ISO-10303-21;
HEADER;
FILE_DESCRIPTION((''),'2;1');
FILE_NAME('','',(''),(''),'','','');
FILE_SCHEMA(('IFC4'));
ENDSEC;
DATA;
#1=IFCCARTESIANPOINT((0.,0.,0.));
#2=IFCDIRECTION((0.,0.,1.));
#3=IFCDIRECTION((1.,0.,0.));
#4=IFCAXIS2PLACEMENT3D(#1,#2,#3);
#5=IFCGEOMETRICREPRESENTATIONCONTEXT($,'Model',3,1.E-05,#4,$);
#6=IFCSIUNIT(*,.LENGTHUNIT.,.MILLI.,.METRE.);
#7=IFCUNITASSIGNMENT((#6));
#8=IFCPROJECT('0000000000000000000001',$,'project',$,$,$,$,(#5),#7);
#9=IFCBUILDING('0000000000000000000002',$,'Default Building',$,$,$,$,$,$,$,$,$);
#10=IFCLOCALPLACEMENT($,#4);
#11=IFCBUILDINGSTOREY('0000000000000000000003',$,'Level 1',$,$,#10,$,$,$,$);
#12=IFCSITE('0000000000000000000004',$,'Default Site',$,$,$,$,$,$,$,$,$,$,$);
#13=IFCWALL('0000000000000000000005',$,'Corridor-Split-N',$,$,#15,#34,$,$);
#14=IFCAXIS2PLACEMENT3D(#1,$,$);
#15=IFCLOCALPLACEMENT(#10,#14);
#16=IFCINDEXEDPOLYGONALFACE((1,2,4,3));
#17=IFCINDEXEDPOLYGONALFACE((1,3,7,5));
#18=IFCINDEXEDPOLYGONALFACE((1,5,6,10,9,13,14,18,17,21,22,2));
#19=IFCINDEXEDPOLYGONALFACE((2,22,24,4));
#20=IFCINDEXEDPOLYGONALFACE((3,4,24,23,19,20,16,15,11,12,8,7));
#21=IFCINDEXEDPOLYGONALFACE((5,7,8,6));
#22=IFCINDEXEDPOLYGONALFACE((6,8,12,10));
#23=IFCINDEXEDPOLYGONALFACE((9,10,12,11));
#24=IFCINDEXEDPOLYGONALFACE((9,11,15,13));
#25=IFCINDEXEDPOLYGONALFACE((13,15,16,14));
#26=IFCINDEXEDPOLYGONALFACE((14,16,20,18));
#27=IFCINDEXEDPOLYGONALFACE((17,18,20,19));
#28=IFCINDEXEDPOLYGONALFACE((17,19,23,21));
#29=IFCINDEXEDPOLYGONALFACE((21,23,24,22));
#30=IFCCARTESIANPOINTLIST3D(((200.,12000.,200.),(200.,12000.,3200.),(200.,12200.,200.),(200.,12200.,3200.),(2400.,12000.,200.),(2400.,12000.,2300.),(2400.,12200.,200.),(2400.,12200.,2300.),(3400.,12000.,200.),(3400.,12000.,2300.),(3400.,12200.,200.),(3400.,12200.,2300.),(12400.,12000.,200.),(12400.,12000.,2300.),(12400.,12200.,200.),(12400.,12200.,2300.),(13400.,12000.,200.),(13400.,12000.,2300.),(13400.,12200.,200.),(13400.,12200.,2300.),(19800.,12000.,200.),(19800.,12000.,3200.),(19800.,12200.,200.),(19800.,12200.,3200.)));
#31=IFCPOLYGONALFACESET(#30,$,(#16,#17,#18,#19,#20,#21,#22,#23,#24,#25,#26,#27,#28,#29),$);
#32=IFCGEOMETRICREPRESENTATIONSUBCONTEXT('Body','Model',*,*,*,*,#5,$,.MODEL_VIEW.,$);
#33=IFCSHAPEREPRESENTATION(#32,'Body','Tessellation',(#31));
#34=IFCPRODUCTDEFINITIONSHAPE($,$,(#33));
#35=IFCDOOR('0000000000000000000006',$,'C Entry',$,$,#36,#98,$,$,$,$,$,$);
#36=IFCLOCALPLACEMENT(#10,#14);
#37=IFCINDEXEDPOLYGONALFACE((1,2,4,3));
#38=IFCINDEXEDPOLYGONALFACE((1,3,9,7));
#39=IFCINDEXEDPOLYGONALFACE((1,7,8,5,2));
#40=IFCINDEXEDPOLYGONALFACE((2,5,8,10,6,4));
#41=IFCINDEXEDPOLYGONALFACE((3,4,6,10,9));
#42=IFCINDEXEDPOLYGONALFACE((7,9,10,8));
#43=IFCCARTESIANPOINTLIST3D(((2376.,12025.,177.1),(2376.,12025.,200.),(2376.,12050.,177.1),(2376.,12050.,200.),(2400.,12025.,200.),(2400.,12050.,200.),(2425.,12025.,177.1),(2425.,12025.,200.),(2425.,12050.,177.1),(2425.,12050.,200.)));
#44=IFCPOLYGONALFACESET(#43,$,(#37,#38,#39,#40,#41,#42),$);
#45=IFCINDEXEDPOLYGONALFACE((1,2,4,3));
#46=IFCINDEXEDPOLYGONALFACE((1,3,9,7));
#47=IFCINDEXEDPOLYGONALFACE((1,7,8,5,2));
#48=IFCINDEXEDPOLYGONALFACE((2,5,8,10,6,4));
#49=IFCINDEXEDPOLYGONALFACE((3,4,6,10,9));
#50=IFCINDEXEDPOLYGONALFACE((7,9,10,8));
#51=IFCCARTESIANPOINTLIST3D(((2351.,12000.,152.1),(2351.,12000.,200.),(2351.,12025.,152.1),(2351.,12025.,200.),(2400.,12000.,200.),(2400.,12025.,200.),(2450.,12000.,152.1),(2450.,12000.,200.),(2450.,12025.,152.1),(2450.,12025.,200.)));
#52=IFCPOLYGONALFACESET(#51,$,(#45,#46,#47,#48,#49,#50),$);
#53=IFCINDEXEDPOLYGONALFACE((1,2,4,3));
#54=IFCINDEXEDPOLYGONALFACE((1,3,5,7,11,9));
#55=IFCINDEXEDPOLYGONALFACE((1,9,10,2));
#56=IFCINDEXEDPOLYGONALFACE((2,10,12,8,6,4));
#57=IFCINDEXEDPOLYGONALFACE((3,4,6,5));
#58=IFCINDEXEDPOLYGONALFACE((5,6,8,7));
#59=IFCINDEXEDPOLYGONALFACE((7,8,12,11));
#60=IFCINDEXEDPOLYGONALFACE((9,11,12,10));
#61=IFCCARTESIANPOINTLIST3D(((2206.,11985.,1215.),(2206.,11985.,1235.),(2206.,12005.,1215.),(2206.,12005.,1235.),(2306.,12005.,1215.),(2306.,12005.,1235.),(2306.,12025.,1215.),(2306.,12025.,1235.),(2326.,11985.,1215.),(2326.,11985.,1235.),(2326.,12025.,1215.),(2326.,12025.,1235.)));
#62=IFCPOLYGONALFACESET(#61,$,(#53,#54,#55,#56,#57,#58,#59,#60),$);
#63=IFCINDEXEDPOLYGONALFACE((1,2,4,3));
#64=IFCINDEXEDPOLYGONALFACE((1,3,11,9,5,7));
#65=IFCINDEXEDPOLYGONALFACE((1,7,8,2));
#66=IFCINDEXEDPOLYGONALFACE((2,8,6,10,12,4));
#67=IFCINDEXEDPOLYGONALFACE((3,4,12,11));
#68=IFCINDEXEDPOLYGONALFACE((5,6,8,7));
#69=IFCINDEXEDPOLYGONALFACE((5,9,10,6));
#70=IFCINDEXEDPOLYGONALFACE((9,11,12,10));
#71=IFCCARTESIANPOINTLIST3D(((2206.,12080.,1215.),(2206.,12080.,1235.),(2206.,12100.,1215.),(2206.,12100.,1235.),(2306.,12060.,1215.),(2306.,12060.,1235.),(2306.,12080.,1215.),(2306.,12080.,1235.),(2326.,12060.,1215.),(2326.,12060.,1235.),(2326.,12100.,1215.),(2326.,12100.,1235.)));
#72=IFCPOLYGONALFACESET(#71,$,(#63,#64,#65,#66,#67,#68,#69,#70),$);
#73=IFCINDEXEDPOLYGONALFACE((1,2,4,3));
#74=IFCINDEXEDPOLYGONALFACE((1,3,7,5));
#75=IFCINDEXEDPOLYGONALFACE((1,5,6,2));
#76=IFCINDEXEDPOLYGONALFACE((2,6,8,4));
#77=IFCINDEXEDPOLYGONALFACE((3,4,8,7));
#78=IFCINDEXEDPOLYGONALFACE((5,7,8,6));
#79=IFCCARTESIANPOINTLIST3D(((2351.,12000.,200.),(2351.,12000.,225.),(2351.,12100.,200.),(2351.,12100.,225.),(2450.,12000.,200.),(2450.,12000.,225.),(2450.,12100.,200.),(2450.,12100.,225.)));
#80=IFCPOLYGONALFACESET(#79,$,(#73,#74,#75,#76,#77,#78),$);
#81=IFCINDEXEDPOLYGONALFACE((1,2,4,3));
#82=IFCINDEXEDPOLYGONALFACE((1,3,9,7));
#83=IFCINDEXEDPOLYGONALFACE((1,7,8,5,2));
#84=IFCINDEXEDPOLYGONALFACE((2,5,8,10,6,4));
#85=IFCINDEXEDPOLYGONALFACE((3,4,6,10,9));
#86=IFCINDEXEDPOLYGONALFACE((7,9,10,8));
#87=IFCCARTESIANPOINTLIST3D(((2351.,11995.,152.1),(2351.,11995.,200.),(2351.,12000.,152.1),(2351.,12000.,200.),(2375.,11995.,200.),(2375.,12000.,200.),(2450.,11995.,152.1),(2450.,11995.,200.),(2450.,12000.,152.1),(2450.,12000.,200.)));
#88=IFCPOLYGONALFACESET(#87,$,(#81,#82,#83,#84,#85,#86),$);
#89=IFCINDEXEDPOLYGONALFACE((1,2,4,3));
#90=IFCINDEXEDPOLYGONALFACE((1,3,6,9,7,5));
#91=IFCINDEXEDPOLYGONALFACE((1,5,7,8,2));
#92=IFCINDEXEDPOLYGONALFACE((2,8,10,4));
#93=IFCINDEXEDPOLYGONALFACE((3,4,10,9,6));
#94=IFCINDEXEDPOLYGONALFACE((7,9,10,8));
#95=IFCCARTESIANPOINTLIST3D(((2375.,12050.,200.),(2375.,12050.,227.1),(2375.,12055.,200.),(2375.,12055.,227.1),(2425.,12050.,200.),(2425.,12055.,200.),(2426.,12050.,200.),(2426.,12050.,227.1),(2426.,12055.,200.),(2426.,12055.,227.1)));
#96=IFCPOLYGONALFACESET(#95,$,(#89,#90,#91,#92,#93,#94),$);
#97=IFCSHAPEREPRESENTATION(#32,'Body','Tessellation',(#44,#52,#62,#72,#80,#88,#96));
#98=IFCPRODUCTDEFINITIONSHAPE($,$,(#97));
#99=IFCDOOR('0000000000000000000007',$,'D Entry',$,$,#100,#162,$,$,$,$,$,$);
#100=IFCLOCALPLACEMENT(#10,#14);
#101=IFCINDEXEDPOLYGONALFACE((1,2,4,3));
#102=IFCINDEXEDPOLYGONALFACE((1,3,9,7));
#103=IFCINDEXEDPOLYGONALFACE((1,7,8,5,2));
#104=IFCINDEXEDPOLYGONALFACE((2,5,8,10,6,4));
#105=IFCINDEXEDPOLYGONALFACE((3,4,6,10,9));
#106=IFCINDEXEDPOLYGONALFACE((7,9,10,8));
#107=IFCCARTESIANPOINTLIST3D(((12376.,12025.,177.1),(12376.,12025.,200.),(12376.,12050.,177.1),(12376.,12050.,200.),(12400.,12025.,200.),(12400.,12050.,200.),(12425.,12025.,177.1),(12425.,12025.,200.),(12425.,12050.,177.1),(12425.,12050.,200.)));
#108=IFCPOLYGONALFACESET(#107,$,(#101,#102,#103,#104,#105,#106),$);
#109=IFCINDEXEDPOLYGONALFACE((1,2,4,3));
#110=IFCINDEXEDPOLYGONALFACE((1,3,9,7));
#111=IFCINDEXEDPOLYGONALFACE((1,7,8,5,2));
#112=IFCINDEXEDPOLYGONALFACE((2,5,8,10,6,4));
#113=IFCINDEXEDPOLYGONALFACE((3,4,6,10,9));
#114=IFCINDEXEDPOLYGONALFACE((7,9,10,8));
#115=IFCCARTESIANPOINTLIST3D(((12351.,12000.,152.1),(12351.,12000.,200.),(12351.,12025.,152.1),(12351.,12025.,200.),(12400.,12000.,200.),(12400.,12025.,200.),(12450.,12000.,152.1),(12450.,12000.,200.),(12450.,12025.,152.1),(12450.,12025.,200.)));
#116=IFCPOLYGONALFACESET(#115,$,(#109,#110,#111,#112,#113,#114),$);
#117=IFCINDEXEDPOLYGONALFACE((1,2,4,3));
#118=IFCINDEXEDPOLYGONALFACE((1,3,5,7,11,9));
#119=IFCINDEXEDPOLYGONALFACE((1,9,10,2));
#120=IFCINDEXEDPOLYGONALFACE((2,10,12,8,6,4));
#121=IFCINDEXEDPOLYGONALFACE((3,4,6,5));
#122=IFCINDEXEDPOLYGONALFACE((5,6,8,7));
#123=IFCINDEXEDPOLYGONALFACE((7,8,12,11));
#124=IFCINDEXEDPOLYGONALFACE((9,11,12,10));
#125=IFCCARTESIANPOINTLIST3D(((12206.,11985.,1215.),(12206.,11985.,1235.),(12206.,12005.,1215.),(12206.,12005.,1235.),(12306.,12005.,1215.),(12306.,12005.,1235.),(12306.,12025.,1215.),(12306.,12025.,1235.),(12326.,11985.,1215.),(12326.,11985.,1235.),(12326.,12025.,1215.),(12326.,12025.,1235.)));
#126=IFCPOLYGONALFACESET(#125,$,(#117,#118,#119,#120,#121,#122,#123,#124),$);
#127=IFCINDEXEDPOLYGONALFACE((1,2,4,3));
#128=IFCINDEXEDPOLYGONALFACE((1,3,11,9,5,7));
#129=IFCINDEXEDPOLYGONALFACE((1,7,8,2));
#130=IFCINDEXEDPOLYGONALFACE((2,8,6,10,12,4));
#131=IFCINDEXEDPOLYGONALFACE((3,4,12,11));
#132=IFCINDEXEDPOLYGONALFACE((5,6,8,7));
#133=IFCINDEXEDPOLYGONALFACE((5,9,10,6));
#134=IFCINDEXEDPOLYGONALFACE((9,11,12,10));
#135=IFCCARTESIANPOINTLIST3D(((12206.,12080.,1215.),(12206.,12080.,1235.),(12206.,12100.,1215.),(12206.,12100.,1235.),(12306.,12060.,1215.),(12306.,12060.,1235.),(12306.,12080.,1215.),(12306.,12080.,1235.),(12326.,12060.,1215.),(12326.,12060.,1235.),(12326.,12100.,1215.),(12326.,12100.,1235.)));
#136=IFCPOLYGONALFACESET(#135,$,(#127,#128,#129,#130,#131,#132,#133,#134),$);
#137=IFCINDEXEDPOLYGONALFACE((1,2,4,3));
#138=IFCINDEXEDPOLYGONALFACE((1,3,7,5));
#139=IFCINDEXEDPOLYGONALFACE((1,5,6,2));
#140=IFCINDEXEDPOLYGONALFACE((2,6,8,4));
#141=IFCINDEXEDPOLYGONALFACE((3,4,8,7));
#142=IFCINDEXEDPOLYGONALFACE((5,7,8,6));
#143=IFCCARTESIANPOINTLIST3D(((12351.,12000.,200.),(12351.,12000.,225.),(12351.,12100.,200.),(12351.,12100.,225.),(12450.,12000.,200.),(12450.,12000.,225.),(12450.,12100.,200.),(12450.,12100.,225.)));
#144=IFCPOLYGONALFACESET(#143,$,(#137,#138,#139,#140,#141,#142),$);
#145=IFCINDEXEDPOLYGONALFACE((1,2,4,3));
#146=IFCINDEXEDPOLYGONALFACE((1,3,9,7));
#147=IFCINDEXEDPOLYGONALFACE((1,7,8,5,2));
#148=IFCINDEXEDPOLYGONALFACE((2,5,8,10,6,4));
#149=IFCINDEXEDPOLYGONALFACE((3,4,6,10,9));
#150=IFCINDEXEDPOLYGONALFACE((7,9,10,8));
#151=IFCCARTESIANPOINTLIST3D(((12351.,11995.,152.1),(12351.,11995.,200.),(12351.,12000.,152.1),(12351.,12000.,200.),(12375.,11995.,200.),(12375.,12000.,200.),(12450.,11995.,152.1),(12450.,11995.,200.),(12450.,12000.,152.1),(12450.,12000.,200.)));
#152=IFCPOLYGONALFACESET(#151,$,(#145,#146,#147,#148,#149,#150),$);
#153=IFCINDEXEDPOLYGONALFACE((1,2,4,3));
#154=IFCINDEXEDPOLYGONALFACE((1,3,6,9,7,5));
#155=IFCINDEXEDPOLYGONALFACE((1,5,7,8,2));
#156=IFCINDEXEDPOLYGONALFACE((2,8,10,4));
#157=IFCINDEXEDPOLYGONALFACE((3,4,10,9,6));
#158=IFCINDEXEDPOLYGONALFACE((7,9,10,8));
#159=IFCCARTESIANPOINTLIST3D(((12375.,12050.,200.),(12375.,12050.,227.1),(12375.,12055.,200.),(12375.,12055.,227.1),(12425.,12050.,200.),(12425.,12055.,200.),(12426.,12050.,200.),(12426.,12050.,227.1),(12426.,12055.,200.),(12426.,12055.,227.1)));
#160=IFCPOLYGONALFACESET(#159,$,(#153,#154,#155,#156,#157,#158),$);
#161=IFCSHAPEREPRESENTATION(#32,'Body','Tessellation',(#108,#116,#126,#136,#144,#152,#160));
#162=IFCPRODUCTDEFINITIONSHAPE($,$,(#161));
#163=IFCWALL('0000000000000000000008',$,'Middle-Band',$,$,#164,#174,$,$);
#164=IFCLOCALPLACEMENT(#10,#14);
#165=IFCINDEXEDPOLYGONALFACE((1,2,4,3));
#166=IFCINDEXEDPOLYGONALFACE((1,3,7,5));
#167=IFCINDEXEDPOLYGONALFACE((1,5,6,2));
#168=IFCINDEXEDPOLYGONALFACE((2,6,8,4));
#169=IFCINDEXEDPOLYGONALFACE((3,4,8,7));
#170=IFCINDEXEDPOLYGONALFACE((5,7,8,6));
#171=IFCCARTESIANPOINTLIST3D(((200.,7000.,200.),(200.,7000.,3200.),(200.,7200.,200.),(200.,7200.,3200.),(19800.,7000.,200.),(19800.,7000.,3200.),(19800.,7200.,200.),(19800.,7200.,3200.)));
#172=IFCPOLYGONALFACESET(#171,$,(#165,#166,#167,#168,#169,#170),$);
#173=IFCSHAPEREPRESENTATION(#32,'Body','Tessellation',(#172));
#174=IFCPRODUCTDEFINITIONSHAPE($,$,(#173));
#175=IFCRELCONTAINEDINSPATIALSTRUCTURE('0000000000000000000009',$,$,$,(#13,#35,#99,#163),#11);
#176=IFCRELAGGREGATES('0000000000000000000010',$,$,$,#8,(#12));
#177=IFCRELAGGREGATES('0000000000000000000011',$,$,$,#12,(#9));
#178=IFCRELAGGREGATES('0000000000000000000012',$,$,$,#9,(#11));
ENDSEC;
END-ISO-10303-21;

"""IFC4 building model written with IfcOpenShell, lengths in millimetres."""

from ifc_helpers import new_model, si_unit, frame, origin_with_axes, place, context, subcontext, project, spatial, line, indexed_curve, outline, extrude, element, fill, save


model = new_model("IFC4")

# Units and contexts
model_context = context("Model", 3, precision=1e-05, world=origin_with_axes())
body_context = subcontext(model_context, "Body", "Model", "MODEL_VIEW")
ifc_project = project(units=[si_unit("LENGTHUNIT", "METRE", prefix="MILLI")], contexts=[model_context])

# Site, building, storey
site = spatial("IfcSite", under=ifc_project, Name="Default Site")
building = spatial("IfcBuilding", under=site, Name="Default Building")
storey_placement = place(None, origin_with_axes())
storey = spatial("IfcBuildingStorey", under=building, at=storey_placement, Name="Level 1")

# Wall, openings, doors
wall_1_placement = place(storey_placement, frame((0.0, 0.0, 200.0), z_axis=(0.0, 0.0, 1.0), x_axis=(1.0, 0.0, 0.0)))
wall_1 = element("IfcWall", 1, at=wall_1_placement, inside=storey, Name="Corridor-Split-N", context=body_context, shape_type="SweptSolid", body=[
    extrude(outline(indexed_curve([(200.0, 12000.0), (19800.0, 12000.0), (19800.0, 12200.0), (200.0, 12200.0), (200.0, 12000.0)])), None, (0.0, 0.0, 1.0), 3000.0),
])
opening_1_placement = place(wall_1_placement, origin_with_axes())
opening_1 = element("IfcOpeningElement", 2, at=opening_1_placement, cuts=wall_1, context=body_context, shape_type="SweptSolid", body=[
    extrude(outline(indexed_curve([(2400.0, 12000.0), (3400.0, 12000.0), (3400.0, 12200.0), (2400.0, 12200.0), (2400.0, 12000.0)])), None, (0.0, 0.0, 1.0), 2100.0),
])
opening_2_placement = place(wall_1_placement, origin_with_axes())
opening_2 = element("IfcOpeningElement", 3, at=opening_2_placement, cuts=wall_1, context=body_context, shape_type="SweptSolid", body=[
    extrude(outline(indexed_curve([(12400.0, 12000.0), (13400.0, 12000.0), (13400.0, 12200.0), (12400.0, 12200.0), (12400.0, 12000.0)])), None, (0.0, 0.0, 1.0), 2100.0),
])
door_1_placement = place(storey_placement, frame((2400.0, 12000.0, 200.0), z_axis=(0.0, 0.0, 1.0), x_axis=(1.0, 0.0, 0.0)))
door_1 = element("IfcDoor", 4, at=door_1_placement, inside=storey, Name="C Entry", context=body_context, shape_type="SweptSolid", body=[
    extrude(outline(indexed_curve([(0.0, 0.0), (0.0, 2.1), (1.0, 2.1), (1.0, 0.0), (-24.0, 0.0), (-24.0, -22.9), (25.0, -22.9), (25.0, 0.0)], segments=[line(1, 2, 3, 4, 5, 6, 7, 8, 1)])), frame((0.0, 25.0, 0.0), z_axis=(0.0, -1.0, 0.0), x_axis=(1.0, 0.0, 0.0)), (0.0, 0.0, -1.0), 25.0),
    extrude(outline(indexed_curve([(0.0, 0.0), (0.0, 2.1), (1.0, 2.1), (1.0, 0.0), (-49.0, 0.0), (-49.0, -47.9), (50.0, -47.9), (50.0, 0.0)], segments=[line(1, 2, 3, 4, 5, 6, 7, 8, 1)])), frame((0.0, 0.0, 0.0), z_axis=(0.0, -1.0, 0.0), x_axis=(1.0, 0.0, 0.0)), (0.0, 0.0, -1.0), 25.0),
    extrude(outline(indexed_curve([(0.0, 0.0), (-49.0, 0.0), (-49.0, 35.0), (0.0, 35.0)], segments=[line(1, 2, 3, 4, 1)])), frame((25.0, 25.0, 25.0), z_axis=(0.0, 0.0, 1.0), x_axis=(1.0, 0.0, 0.0)), (0.0, 0.0, 1.0), -47.9),
    extrude(outline(indexed_curve([(0.0, 0.0), (0.0, -40.0), (-120.0, -40.0), (-120.0, -20.0), (-20.0, -20.0), (-20.0, 0.0)], segments=[line(1, 2, 3, 4, 5, 6, 1)])), frame((-74.0, 25.0, 1015.0), z_axis=(0.0, 0.0, 1.0), x_axis=(1.0, 0.0, 0.0)), (0.0, 0.0, 1.0), 20.0),
    extrude(outline(indexed_curve([(0.0, 0.0), (0.0, 40.0), (-120.0, 40.0), (-120.0, 20.0), (-20.0, 20.0), (-20.0, 0.0)], segments=[line(1, 2, 3, 4, 5, 6, 1)])), frame((-74.0, 60.0, 1015.0), z_axis=(0.0, 0.0, 1.0), x_axis=(1.0, 0.0, 0.0)), (0.0, 0.0, 1.0), 20.0),
    extrude(outline(indexed_curve([(0.0, 0.0), (-99.0, 0.0), (-99.0, 100.0), (0.0, 100.0)], segments=[line(1, 2, 3, 4, 1)])), frame((50.0, 0.0, 0.0), z_axis=(0.0, 0.0, 1.0), x_axis=(1.0, 0.0, 0.0)), (0.0, 0.0, 1.0), 25.0),
    extrude(outline(indexed_curve([(0.0, 0.0), (0.0, 27.1), (51.0, 27.1), (51.0, 0.0), (-24.0, 0.0), (-24.0, -47.9), (75.0, -47.9), (75.0, 0.0)], segments=[line(1, 2, 3, 4, 5, 6, 7, 8, 1)])), frame((-25.0, -5.0, 0.0), z_axis=(0.0, -1.0, 0.0), x_axis=(1.0, 0.0, 0.0)), (0.0, 0.0, -1.0), 5.0),
    extrude(outline(indexed_curve([(0.0, 0.0), (0.0, 27.1), (51.0, 27.1), (51.0, 0.0), (1.0, 0.0), (1.0, -22.9), (50.0, -22.9), (50.0, 0.0)], segments=[line(1, 2, 3, 4, 5, 6, 7, 8, 1)])), frame((-25.0, 50.0, 0.0), z_axis=(0.0, -1.0, 0.0), x_axis=(1.0, 0.0, 0.0)), (0.0, 0.0, -1.0), 5.0),
])
fill(opening_1, door_1)
door_2_placement = place(storey_placement, frame((12400.0, 12000.0, 200.0), z_axis=(0.0, 0.0, 1.0), x_axis=(1.0, 0.0, 0.0)))
door_2 = element("IfcDoor", 5, at=door_2_placement, inside=storey, Name="D Entry", context=body_context, shape_type="SweptSolid", body=[
    extrude(outline(indexed_curve([(0.0, 0.0), (0.0, 2.1), (1.0, 2.1), (1.0, 0.0), (-24.0, 0.0), (-24.0, -22.9), (25.0, -22.9), (25.0, 0.0)], segments=[line(1, 2, 3, 4, 5, 6, 7, 8, 1)])), frame((0.0, 25.0, 0.0), z_axis=(0.0, -1.0, 0.0), x_axis=(1.0, 0.0, 0.0)), (0.0, 0.0, -1.0), 25.0),
    extrude(outline(indexed_curve([(0.0, 0.0), (0.0, 2.1), (1.0, 2.1), (1.0, 0.0), (-49.0, 0.0), (-49.0, -47.9), (50.0, -47.9), (50.0, 0.0)], segments=[line(1, 2, 3, 4, 5, 6, 7, 8, 1)])), frame((0.0, 0.0, 0.0), z_axis=(0.0, -1.0, 0.0), x_axis=(1.0, 0.0, 0.0)), (0.0, 0.0, -1.0), 25.0),
    extrude(outline(indexed_curve([(0.0, 0.0), (-49.0, 0.0), (-49.0, 35.0), (0.0, 35.0)], segments=[line(1, 2, 3, 4, 1)])), frame((25.0, 25.0, 25.0), z_axis=(0.0, 0.0, 1.0), x_axis=(1.0, 0.0, 0.0)), (0.0, 0.0, 1.0), -47.9),
    extrude(outline(indexed_curve([(0.0, 0.0), (0.0, -40.0), (-120.0, -40.0), (-120.0, -20.0), (-20.0, -20.0), (-20.0, 0.0)], segments=[line(1, 2, 3, 4, 5, 6, 1)])), frame((-74.0, 25.0, 1015.0), z_axis=(0.0, 0.0, 1.0), x_axis=(1.0, 0.0, 0.0)), (0.0, 0.0, 1.0), 20.0),
    extrude(outline(indexed_curve([(0.0, 0.0), (0.0, 40.0), (-120.0, 40.0), (-120.0, 20.0), (-20.0, 20.0), (-20.0, 0.0)], segments=[line(1, 2, 3, 4, 5, 6, 1)])), frame((-74.0, 60.0, 1015.0), z_axis=(0.0, 0.0, 1.0), x_axis=(1.0, 0.0, 0.0)), (0.0, 0.0, 1.0), 20.0),
    extrude(outline(indexed_curve([(0.0, 0.0), (-99.0, 0.0), (-99.0, 100.0), (0.0, 100.0)], segments=[line(1, 2, 3, 4, 1)])), frame((50.0, 0.0, 0.0), z_axis=(0.0, 0.0, 1.0), x_axis=(1.0, 0.0, 0.0)), (0.0, 0.0, 1.0), 25.0),
    extrude(outline(indexed_curve([(0.0, 0.0), (0.0, 27.1), (51.0, 27.1), (51.0, 0.0), (-24.0, 0.0), (-24.0, -47.9), (75.0, -47.9), (75.0, 0.0)], segments=[line(1, 2, 3, 4, 5, 6, 7, 8, 1)])), frame((-25.0, -5.0, 0.0), z_axis=(0.0, -1.0, 0.0), x_axis=(1.0, 0.0, 0.0)), (0.0, 0.0, -1.0), 5.0),
    extrude(outline(indexed_curve([(0.0, 0.0), (0.0, 27.1), (51.0, 27.1), (51.0, 0.0), (1.0, 0.0), (1.0, -22.9), (50.0, -22.9), (50.0, 0.0)], segments=[line(1, 2, 3, 4, 5, 6, 7, 8, 1)])), frame((-25.0, 50.0, 0.0), z_axis=(0.0, -1.0, 0.0), x_axis=(1.0, 0.0, 0.0)), (0.0, 0.0, -1.0), 5.0),
])
fill(opening_2, door_2)

# Wall
wall_2_placement = place(storey_placement, frame((0.0, 0.0, 200.0), z_axis=(0.0, 0.0, 1.0), x_axis=(1.0, 0.0, 0.0)))
element("IfcWall", 6, at=wall_2_placement, inside=storey, Name="Middle-Band", context=body_context, shape_type="SweptSolid", body=[
    extrude(outline(indexed_curve([(200.0, 7000.0), (19800.0, 7000.0), (19800.0, 7200.0), (200.0, 7200.0), (200.0, 7000.0)])), None, (0.0, 0.0, 1.0), 3000.0),
])

save(model, "model.ifc")
